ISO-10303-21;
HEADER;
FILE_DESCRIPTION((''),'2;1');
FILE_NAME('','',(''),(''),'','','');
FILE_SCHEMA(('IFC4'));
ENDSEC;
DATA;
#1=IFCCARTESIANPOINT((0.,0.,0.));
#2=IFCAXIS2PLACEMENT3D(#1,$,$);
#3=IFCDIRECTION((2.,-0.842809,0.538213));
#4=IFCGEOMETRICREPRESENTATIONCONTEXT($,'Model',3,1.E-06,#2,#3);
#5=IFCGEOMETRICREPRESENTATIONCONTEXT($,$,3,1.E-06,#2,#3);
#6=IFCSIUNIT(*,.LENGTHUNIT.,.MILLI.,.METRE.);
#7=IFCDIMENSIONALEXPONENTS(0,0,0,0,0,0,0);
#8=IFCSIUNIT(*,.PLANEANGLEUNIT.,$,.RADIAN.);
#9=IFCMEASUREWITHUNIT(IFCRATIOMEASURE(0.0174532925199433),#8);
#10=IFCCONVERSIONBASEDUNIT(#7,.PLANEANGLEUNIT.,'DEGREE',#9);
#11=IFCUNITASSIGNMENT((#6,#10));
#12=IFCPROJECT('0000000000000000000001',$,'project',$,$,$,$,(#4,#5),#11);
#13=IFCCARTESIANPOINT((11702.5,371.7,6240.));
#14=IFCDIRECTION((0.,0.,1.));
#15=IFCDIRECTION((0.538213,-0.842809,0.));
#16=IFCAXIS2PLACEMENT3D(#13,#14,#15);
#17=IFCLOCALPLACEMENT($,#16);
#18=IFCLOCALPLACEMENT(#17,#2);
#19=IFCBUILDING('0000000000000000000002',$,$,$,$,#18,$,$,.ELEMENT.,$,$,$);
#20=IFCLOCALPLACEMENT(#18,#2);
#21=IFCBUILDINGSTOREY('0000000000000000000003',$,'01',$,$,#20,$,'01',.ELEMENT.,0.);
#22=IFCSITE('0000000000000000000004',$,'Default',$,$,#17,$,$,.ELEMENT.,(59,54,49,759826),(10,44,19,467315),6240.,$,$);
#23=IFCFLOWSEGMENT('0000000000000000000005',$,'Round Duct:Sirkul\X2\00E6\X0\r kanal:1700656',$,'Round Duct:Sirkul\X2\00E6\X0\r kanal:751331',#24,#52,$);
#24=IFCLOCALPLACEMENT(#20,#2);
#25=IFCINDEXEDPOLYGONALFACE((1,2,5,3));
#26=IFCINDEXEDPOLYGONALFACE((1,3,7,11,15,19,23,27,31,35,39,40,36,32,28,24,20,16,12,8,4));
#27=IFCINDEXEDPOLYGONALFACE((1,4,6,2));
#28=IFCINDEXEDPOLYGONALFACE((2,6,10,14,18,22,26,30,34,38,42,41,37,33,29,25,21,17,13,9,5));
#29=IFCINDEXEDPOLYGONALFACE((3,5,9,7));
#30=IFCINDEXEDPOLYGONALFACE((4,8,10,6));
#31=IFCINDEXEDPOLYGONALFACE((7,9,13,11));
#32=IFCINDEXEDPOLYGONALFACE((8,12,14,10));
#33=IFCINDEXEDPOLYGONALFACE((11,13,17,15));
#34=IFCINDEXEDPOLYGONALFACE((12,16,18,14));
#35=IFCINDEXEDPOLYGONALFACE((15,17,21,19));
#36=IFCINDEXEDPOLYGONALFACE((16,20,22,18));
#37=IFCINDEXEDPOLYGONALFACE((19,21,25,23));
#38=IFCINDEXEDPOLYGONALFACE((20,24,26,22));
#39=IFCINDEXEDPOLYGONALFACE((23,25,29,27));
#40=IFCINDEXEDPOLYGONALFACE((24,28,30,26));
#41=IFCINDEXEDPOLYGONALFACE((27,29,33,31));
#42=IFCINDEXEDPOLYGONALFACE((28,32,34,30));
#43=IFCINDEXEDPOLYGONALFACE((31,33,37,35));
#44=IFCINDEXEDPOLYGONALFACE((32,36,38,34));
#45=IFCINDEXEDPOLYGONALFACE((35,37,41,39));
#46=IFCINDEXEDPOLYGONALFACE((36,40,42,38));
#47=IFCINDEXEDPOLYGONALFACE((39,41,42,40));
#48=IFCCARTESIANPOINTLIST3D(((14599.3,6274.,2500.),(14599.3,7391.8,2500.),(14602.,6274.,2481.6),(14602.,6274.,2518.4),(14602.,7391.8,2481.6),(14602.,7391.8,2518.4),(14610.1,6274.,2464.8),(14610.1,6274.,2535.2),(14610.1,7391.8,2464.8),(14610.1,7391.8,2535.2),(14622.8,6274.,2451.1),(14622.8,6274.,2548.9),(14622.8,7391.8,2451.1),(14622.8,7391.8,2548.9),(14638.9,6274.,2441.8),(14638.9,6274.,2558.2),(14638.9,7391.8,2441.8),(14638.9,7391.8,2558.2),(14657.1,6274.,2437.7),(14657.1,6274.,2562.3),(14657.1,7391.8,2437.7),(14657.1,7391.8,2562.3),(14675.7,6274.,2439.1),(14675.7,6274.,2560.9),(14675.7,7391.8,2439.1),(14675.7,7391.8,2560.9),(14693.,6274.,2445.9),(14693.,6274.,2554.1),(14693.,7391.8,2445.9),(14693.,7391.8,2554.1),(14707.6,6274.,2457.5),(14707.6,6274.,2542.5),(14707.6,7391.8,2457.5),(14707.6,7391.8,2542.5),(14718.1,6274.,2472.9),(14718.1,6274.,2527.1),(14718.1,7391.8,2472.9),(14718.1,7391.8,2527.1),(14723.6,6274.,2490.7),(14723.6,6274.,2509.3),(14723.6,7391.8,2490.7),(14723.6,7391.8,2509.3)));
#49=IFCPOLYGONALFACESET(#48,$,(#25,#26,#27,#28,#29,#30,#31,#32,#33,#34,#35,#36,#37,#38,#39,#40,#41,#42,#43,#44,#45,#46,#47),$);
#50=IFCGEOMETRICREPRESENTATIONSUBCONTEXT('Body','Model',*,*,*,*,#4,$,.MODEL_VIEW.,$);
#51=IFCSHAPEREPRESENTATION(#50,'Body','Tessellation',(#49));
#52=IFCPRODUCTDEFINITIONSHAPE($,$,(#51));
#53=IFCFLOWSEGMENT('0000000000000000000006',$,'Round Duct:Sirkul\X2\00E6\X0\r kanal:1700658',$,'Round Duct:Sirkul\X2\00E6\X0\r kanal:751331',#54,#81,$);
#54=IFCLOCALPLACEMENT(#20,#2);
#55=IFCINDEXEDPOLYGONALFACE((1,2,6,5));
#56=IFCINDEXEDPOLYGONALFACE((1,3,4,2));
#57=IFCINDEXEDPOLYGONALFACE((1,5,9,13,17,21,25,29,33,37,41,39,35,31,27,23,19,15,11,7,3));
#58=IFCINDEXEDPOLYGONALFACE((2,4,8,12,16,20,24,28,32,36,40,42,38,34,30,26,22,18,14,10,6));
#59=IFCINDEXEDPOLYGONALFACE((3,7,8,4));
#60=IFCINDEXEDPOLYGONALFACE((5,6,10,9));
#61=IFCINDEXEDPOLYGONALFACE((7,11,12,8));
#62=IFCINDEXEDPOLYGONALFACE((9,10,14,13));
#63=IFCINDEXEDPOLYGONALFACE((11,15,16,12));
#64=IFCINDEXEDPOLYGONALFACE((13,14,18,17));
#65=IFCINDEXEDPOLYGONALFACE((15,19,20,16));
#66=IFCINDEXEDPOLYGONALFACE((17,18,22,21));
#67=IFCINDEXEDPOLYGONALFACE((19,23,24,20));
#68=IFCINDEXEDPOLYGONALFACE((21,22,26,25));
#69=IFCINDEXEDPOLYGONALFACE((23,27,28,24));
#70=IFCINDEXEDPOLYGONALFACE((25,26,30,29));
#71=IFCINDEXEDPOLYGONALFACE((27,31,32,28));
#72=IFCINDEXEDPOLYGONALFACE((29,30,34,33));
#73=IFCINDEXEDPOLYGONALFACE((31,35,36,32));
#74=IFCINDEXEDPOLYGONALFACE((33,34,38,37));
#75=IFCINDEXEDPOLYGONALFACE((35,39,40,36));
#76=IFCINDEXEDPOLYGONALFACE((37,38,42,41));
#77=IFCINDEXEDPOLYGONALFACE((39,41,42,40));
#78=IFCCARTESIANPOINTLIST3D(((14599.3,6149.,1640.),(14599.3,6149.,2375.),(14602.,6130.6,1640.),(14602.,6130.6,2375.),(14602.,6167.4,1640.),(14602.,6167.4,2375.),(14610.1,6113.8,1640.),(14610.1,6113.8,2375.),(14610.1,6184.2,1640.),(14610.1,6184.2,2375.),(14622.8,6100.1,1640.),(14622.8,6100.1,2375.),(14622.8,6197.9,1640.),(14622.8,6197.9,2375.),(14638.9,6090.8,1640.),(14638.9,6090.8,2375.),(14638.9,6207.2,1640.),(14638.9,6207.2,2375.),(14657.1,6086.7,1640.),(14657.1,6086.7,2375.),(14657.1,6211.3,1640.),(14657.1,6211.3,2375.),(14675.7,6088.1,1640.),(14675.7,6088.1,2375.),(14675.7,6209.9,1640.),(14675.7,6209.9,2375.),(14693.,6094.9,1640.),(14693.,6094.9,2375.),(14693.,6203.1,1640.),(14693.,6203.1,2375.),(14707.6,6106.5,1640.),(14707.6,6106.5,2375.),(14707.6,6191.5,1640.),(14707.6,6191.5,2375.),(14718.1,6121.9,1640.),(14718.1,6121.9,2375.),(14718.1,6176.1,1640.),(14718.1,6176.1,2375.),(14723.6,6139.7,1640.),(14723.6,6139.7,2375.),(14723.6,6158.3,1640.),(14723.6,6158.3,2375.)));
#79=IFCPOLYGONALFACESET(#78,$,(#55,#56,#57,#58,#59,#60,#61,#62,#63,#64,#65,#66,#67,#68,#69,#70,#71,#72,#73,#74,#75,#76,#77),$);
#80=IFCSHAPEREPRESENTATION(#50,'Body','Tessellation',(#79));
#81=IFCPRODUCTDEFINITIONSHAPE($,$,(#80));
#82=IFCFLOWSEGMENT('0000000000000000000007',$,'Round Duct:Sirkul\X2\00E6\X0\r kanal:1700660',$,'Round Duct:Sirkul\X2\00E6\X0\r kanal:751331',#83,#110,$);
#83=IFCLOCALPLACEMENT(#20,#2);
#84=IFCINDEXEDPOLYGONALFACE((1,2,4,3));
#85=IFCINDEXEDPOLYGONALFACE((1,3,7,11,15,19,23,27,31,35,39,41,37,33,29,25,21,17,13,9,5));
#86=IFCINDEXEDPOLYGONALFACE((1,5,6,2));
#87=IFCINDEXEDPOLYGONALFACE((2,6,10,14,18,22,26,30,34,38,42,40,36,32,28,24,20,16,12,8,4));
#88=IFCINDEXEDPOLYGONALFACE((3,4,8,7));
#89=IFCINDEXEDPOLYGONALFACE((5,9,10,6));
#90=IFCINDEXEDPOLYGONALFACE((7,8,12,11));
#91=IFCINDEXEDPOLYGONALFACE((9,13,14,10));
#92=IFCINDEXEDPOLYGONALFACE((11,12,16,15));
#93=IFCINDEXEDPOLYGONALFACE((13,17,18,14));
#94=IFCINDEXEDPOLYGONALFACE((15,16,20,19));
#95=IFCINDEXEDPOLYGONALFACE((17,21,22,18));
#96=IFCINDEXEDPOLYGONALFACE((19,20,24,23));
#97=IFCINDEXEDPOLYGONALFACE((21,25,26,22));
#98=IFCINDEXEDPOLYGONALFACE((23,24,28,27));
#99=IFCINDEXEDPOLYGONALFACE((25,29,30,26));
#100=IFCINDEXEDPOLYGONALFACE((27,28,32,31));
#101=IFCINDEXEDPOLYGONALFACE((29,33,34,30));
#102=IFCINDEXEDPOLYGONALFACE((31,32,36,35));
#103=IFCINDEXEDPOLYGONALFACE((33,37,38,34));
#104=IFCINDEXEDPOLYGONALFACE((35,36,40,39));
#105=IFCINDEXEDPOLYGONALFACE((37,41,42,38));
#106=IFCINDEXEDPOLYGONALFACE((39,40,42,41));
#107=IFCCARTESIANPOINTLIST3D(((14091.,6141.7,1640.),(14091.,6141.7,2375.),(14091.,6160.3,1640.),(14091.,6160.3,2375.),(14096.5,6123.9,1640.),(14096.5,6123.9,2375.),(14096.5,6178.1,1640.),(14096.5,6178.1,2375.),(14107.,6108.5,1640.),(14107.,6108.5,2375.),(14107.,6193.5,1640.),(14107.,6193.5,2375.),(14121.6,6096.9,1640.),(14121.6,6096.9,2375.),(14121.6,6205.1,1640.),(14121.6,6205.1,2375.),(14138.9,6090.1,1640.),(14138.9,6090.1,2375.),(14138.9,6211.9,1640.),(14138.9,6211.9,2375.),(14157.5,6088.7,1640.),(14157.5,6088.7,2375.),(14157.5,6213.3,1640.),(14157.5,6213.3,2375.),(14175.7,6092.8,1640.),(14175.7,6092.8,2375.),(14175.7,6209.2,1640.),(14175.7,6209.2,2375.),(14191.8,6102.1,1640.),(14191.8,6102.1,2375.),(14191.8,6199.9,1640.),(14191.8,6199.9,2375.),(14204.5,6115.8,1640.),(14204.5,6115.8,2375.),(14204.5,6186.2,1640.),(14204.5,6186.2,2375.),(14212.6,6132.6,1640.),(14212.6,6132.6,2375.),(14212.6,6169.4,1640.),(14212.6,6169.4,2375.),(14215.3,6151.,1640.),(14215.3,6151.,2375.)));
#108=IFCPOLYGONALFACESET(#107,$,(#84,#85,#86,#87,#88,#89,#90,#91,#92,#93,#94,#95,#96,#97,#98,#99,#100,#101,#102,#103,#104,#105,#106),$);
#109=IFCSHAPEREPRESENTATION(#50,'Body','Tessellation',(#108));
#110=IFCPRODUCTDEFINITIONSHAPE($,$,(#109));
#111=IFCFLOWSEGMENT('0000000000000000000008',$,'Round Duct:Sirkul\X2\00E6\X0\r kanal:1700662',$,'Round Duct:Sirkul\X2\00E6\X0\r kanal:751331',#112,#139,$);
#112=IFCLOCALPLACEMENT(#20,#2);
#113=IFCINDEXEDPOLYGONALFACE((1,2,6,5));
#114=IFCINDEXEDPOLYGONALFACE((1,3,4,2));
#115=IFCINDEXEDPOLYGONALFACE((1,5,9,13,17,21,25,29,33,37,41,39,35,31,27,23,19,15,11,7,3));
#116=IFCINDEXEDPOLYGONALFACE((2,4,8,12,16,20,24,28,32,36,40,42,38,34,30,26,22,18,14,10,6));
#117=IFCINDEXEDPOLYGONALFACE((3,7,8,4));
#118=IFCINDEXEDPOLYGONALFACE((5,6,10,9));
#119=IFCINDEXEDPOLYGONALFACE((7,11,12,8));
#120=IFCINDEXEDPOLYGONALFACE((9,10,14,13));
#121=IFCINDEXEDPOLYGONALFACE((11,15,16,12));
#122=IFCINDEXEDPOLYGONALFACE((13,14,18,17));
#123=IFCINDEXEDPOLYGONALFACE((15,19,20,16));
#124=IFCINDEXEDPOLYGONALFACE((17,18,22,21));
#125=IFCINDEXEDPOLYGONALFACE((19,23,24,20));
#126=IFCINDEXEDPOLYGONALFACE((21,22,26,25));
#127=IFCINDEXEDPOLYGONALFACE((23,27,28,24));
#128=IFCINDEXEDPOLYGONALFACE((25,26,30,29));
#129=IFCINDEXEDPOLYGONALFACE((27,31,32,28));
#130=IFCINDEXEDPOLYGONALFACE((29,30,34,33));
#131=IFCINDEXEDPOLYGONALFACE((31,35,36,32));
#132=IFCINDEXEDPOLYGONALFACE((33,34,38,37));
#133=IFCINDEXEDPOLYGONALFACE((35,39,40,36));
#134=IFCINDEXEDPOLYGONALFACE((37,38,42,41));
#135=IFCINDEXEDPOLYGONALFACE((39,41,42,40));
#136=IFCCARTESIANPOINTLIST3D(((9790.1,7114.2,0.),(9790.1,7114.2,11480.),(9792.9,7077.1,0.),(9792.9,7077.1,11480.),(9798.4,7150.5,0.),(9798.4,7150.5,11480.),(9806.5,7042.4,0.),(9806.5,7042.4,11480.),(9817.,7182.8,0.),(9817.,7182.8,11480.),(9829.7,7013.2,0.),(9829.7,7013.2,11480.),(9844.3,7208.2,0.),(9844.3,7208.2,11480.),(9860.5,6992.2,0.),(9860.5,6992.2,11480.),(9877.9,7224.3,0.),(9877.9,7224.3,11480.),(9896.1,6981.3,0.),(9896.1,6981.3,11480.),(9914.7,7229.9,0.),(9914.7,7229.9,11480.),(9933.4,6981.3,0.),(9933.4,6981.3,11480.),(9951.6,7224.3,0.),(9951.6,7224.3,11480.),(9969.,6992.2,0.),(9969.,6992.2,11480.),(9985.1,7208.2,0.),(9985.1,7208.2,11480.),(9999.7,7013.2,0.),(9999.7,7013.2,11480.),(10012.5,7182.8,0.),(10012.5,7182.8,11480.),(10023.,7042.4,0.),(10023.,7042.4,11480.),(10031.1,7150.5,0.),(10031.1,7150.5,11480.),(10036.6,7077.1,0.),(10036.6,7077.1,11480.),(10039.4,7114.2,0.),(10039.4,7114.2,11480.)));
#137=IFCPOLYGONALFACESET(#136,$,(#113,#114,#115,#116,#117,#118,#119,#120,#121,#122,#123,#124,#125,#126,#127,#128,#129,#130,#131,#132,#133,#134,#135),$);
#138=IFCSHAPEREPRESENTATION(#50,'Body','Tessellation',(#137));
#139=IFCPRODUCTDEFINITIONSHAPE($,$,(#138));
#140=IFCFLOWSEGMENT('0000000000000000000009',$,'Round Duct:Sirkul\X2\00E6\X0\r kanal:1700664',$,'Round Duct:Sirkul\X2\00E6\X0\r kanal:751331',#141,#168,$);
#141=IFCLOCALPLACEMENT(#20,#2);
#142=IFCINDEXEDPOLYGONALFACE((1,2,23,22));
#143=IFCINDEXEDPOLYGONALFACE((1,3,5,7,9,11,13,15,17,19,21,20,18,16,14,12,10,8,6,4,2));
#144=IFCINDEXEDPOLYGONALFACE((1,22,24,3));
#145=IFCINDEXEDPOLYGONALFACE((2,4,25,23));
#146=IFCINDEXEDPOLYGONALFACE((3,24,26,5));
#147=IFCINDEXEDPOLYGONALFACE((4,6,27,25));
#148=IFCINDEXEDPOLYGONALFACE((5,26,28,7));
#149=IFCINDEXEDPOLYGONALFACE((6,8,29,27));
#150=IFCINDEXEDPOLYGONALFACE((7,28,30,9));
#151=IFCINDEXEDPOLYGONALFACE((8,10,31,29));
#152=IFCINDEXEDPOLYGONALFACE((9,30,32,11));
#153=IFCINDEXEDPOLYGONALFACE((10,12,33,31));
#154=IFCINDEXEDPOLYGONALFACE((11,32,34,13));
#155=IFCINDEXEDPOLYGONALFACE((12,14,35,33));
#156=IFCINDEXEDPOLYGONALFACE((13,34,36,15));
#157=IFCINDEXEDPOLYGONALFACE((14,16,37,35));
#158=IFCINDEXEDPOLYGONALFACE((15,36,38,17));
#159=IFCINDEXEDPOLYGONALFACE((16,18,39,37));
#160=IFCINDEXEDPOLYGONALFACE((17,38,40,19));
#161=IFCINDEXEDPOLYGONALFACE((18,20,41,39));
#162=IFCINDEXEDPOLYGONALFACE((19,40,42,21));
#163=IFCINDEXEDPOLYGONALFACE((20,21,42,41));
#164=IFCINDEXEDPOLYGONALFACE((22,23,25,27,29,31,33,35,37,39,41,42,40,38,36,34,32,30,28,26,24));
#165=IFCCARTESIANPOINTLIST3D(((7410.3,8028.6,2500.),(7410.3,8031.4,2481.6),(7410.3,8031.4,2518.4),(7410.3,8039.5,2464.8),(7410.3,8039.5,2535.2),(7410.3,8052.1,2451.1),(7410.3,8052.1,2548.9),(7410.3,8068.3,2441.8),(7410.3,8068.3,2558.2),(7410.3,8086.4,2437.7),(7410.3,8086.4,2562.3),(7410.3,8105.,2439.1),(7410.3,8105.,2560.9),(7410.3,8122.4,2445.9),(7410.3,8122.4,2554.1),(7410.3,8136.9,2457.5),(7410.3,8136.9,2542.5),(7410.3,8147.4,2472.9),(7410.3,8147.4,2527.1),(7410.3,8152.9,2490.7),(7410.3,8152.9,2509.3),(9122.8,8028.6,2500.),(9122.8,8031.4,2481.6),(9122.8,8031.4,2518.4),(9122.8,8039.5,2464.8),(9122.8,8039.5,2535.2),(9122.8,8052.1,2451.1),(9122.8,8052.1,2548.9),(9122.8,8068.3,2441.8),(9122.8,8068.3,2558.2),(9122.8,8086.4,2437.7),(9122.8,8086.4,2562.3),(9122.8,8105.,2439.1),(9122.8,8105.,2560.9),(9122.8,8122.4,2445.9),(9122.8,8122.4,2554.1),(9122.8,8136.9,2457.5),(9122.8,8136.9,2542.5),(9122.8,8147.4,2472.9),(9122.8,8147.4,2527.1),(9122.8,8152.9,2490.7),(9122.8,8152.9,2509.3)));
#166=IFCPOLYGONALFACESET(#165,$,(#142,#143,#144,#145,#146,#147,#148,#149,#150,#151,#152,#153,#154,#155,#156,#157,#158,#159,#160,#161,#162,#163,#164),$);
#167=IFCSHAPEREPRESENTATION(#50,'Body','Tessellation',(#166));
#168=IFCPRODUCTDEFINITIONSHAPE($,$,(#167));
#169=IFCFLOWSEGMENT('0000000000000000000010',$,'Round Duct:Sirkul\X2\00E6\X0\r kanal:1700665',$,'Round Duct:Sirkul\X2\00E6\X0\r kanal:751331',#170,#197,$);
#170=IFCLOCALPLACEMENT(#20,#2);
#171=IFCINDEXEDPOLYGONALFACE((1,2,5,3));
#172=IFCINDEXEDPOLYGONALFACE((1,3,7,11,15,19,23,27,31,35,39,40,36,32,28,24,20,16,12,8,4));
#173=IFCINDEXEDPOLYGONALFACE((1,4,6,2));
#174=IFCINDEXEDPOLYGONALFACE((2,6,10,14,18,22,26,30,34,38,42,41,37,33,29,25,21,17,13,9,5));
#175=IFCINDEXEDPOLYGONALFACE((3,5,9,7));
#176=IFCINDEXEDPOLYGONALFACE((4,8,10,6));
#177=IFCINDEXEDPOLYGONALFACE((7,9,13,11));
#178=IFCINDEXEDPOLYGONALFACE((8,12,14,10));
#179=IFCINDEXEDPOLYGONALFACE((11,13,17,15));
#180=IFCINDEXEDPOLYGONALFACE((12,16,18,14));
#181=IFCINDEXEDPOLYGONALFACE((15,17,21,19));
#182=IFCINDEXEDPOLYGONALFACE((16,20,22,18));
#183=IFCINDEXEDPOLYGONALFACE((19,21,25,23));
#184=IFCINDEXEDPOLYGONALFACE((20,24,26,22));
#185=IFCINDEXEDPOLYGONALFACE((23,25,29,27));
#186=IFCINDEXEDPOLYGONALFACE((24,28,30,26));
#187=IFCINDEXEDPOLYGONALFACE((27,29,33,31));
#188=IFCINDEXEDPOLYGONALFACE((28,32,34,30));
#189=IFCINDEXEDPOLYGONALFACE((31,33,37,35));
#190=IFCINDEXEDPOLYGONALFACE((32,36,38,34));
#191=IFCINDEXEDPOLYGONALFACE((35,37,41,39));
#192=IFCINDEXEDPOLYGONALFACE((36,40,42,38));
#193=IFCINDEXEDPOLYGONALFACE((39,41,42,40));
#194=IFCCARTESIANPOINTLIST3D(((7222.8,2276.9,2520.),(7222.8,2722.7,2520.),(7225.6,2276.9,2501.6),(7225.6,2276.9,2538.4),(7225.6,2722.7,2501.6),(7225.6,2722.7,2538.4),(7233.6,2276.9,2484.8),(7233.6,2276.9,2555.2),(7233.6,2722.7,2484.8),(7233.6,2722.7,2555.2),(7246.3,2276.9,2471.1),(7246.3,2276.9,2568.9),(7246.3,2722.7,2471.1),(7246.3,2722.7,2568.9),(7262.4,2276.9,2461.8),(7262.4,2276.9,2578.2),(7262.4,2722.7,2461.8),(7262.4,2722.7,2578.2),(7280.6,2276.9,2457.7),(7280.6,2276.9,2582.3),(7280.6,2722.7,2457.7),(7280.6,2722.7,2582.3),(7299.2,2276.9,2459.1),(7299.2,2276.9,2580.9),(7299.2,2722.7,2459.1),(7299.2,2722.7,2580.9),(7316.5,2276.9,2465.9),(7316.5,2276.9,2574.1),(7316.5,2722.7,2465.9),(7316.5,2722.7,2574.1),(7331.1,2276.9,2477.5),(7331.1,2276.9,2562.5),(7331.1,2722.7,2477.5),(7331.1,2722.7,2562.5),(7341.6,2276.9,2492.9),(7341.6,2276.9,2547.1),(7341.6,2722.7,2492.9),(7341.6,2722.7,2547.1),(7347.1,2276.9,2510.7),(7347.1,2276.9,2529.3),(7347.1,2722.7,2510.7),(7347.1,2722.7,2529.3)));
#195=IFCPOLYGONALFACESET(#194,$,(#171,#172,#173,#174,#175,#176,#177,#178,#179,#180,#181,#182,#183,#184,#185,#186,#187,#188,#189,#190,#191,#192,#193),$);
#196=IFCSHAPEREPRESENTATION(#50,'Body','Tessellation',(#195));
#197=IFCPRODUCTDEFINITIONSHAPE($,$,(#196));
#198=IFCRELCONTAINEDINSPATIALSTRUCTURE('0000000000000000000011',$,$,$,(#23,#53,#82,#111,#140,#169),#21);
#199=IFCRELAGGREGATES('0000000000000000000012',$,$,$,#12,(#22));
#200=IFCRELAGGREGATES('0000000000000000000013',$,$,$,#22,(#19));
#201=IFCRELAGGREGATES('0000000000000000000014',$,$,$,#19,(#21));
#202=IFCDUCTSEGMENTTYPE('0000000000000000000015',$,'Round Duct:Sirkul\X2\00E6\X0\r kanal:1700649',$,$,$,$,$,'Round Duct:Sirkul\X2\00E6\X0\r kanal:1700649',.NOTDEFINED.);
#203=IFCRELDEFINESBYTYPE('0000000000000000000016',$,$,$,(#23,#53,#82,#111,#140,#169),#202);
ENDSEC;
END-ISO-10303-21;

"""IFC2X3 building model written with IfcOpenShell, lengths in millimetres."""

from ifc_helpers import new_model, entity, si_unit, converted_unit, direction, frame, frame_2d, origin, origin_2d_with_axis, place, context, subcontext, project, spatial, circle, extrude, type_object, element, save


model = new_model("IFC2X3")

# Units and contexts
model_context = context("Model", 3, precision=1e-06, world=origin(), true_north=direction((2.0, -0.842809, 0.538213)))
context_of_model = context(None, 3, precision=1e-06, world=origin(), true_north=direction((2.0, -0.842809, 0.538213)))
body_context = subcontext(model_context, "Body", "Model", "MODEL_VIEW")
ifc_project = project(units=[si_unit("LENGTHUNIT", "METRE", prefix="MILLI"), converted_unit("PLANEANGLEUNIT", "DEGREE", entity("IfcRatioMeasure", 0.0174532925199433), si_unit("PLANEANGLEUNIT", "RADIAN"), dimensions=[0, 0, 0, 0, 0, 0, 0])], contexts=[model_context, context_of_model])

# Site, building, storey
site_placement = place(None, frame((11702.5, 371.7, 6240.0), z_axis=(0.0, 0.0, 1.0), x_axis=(0.538213, -0.842809, 0.0)))
site = spatial("IfcSite", under=ifc_project, at=site_placement, Name="Default", CompositionType="ELEMENT", RefLatitude=(59, 54, 49, 759826), RefLongitude=(10, 44, 19, 467315), RefElevation=6240.0)
building_placement = place(site_placement, origin())
building = spatial("IfcBuilding", under=site, at=building_placement, CompositionType="ELEMENT")
storey_placement = place(building_placement, origin())
storey = spatial("IfcBuildingStorey", under=building, at=storey_placement, Name="01", LongName="01", CompositionType="ELEMENT", Elevation=0.0)

# Flow segments
duct_segment_type = type_object("IfcDuctSegmentType", Name="Round Duct:Sirkulær kanal:1700649", ElementType="Round Duct:Sirkulær kanal:1700649", PredefinedType="NOTDEFINED")
flow_segment_1_placement = place(storey_placement, origin())
element("IfcFlowSegment", 1, at=flow_segment_1_placement, inside=storey, type_object=duct_segment_type, Name="Round Duct:Sirkulær kanal:1700656", ObjectType="Round Duct:Sirkulær kanal:751331", context=body_context, shape_type="SweptSolid", body=[
    extrude(circle(Radius=62.5, at=origin_2d_with_axis()), frame((14661.8, 6274.0, 2500.0), z_axis=(0.0, 1.0, 0.0), x_axis=(-1.0, 0.0, 0.0)), (0.0, 0.0, 1.0), 1117.8),
])
flow_segment_2_placement = place(storey_placement, origin())
element("IfcFlowSegment", 2, at=flow_segment_2_placement, inside=storey, type_object=duct_segment_type, Name="Round Duct:Sirkulær kanal:1700658", ObjectType="Round Duct:Sirkulær kanal:751331", context=body_context, shape_type="SweptSolid", body=[
    extrude(circle(Radius=62.5, at=origin_2d_with_axis()), frame((14661.8, 6149.0, 1640.0), z_axis=(0.0, 0.0, 1.0), x_axis=(-1.0, 0.0, 0.0)), (0.0, 0.0, 1.0), 735.0),
])
flow_segment_3_placement = place(storey_placement, origin())
element("IfcFlowSegment", 3, at=flow_segment_3_placement, inside=storey, type_object=duct_segment_type, Name="Round Duct:Sirkulær kanal:1700660", ObjectType="Round Duct:Sirkulær kanal:751331", context=body_context, shape_type="SweptSolid", body=[
    extrude(circle(Radius=62.5, at=origin_2d_with_axis()), frame((14152.8, 6151.0, 1640.0)), (0.0, 0.0, 1.0), 735.0),
])
flow_segment_4_placement = place(storey_placement, origin())
element("IfcFlowSegment", 4, at=flow_segment_4_placement, inside=storey, type_object=duct_segment_type, Name="Round Duct:Sirkulær kanal:1700662", ObjectType="Round Duct:Sirkulær kanal:751331", context=body_context, shape_type="SweptSolid", body=[
    extrude(circle(Radius=125.0, at=frame_2d((0.0, 0.0), x_axis=(1.0, 0.0))), frame((9914.7, 7104.9, 0.0), z_axis=(0.0, 0.0, 1.0), x_axis=(0.0, 1.0, 0.0)), (0.0, 0.0, 1.0), 11480.0),
])
flow_segment_5_placement = place(storey_placement, origin())
element("IfcFlowSegment", 5, at=flow_segment_5_placement, inside=storey, type_object=duct_segment_type, Name="Round Duct:Sirkulær kanal:1700664", ObjectType="Round Duct:Sirkulær kanal:751331", context=body_context, shape_type="SweptSolid", body=[
    extrude(circle(Radius=62.5, at=origin_2d_with_axis()), frame((7410.3, 8091.1, 2500.0), z_axis=(1.0, 0.0, 0.0), x_axis=(0.0, -1.0, 0.0)), (0.0, 0.0, 1.0), 1712.5),
])
flow_segment_6_placement = place(storey_placement, origin())
element("IfcFlowSegment", 6, at=flow_segment_6_placement, inside=storey, type_object=duct_segment_type, Name="Round Duct:Sirkulær kanal:1700665", ObjectType="Round Duct:Sirkulær kanal:751331", context=body_context, shape_type="SweptSolid", body=[
    extrude(circle(Radius=62.5, at=frame_2d((0.0, 0.0), x_axis=(1.0, 0.0))), frame((7285.3, 2276.9, 2520.0), z_axis=(0.0, 1.0, 0.0), x_axis=(-1.0, 0.0, 0.0)), (0.0, 0.0, 1.0), 445.8),
])

save(model, "model.ifc")
